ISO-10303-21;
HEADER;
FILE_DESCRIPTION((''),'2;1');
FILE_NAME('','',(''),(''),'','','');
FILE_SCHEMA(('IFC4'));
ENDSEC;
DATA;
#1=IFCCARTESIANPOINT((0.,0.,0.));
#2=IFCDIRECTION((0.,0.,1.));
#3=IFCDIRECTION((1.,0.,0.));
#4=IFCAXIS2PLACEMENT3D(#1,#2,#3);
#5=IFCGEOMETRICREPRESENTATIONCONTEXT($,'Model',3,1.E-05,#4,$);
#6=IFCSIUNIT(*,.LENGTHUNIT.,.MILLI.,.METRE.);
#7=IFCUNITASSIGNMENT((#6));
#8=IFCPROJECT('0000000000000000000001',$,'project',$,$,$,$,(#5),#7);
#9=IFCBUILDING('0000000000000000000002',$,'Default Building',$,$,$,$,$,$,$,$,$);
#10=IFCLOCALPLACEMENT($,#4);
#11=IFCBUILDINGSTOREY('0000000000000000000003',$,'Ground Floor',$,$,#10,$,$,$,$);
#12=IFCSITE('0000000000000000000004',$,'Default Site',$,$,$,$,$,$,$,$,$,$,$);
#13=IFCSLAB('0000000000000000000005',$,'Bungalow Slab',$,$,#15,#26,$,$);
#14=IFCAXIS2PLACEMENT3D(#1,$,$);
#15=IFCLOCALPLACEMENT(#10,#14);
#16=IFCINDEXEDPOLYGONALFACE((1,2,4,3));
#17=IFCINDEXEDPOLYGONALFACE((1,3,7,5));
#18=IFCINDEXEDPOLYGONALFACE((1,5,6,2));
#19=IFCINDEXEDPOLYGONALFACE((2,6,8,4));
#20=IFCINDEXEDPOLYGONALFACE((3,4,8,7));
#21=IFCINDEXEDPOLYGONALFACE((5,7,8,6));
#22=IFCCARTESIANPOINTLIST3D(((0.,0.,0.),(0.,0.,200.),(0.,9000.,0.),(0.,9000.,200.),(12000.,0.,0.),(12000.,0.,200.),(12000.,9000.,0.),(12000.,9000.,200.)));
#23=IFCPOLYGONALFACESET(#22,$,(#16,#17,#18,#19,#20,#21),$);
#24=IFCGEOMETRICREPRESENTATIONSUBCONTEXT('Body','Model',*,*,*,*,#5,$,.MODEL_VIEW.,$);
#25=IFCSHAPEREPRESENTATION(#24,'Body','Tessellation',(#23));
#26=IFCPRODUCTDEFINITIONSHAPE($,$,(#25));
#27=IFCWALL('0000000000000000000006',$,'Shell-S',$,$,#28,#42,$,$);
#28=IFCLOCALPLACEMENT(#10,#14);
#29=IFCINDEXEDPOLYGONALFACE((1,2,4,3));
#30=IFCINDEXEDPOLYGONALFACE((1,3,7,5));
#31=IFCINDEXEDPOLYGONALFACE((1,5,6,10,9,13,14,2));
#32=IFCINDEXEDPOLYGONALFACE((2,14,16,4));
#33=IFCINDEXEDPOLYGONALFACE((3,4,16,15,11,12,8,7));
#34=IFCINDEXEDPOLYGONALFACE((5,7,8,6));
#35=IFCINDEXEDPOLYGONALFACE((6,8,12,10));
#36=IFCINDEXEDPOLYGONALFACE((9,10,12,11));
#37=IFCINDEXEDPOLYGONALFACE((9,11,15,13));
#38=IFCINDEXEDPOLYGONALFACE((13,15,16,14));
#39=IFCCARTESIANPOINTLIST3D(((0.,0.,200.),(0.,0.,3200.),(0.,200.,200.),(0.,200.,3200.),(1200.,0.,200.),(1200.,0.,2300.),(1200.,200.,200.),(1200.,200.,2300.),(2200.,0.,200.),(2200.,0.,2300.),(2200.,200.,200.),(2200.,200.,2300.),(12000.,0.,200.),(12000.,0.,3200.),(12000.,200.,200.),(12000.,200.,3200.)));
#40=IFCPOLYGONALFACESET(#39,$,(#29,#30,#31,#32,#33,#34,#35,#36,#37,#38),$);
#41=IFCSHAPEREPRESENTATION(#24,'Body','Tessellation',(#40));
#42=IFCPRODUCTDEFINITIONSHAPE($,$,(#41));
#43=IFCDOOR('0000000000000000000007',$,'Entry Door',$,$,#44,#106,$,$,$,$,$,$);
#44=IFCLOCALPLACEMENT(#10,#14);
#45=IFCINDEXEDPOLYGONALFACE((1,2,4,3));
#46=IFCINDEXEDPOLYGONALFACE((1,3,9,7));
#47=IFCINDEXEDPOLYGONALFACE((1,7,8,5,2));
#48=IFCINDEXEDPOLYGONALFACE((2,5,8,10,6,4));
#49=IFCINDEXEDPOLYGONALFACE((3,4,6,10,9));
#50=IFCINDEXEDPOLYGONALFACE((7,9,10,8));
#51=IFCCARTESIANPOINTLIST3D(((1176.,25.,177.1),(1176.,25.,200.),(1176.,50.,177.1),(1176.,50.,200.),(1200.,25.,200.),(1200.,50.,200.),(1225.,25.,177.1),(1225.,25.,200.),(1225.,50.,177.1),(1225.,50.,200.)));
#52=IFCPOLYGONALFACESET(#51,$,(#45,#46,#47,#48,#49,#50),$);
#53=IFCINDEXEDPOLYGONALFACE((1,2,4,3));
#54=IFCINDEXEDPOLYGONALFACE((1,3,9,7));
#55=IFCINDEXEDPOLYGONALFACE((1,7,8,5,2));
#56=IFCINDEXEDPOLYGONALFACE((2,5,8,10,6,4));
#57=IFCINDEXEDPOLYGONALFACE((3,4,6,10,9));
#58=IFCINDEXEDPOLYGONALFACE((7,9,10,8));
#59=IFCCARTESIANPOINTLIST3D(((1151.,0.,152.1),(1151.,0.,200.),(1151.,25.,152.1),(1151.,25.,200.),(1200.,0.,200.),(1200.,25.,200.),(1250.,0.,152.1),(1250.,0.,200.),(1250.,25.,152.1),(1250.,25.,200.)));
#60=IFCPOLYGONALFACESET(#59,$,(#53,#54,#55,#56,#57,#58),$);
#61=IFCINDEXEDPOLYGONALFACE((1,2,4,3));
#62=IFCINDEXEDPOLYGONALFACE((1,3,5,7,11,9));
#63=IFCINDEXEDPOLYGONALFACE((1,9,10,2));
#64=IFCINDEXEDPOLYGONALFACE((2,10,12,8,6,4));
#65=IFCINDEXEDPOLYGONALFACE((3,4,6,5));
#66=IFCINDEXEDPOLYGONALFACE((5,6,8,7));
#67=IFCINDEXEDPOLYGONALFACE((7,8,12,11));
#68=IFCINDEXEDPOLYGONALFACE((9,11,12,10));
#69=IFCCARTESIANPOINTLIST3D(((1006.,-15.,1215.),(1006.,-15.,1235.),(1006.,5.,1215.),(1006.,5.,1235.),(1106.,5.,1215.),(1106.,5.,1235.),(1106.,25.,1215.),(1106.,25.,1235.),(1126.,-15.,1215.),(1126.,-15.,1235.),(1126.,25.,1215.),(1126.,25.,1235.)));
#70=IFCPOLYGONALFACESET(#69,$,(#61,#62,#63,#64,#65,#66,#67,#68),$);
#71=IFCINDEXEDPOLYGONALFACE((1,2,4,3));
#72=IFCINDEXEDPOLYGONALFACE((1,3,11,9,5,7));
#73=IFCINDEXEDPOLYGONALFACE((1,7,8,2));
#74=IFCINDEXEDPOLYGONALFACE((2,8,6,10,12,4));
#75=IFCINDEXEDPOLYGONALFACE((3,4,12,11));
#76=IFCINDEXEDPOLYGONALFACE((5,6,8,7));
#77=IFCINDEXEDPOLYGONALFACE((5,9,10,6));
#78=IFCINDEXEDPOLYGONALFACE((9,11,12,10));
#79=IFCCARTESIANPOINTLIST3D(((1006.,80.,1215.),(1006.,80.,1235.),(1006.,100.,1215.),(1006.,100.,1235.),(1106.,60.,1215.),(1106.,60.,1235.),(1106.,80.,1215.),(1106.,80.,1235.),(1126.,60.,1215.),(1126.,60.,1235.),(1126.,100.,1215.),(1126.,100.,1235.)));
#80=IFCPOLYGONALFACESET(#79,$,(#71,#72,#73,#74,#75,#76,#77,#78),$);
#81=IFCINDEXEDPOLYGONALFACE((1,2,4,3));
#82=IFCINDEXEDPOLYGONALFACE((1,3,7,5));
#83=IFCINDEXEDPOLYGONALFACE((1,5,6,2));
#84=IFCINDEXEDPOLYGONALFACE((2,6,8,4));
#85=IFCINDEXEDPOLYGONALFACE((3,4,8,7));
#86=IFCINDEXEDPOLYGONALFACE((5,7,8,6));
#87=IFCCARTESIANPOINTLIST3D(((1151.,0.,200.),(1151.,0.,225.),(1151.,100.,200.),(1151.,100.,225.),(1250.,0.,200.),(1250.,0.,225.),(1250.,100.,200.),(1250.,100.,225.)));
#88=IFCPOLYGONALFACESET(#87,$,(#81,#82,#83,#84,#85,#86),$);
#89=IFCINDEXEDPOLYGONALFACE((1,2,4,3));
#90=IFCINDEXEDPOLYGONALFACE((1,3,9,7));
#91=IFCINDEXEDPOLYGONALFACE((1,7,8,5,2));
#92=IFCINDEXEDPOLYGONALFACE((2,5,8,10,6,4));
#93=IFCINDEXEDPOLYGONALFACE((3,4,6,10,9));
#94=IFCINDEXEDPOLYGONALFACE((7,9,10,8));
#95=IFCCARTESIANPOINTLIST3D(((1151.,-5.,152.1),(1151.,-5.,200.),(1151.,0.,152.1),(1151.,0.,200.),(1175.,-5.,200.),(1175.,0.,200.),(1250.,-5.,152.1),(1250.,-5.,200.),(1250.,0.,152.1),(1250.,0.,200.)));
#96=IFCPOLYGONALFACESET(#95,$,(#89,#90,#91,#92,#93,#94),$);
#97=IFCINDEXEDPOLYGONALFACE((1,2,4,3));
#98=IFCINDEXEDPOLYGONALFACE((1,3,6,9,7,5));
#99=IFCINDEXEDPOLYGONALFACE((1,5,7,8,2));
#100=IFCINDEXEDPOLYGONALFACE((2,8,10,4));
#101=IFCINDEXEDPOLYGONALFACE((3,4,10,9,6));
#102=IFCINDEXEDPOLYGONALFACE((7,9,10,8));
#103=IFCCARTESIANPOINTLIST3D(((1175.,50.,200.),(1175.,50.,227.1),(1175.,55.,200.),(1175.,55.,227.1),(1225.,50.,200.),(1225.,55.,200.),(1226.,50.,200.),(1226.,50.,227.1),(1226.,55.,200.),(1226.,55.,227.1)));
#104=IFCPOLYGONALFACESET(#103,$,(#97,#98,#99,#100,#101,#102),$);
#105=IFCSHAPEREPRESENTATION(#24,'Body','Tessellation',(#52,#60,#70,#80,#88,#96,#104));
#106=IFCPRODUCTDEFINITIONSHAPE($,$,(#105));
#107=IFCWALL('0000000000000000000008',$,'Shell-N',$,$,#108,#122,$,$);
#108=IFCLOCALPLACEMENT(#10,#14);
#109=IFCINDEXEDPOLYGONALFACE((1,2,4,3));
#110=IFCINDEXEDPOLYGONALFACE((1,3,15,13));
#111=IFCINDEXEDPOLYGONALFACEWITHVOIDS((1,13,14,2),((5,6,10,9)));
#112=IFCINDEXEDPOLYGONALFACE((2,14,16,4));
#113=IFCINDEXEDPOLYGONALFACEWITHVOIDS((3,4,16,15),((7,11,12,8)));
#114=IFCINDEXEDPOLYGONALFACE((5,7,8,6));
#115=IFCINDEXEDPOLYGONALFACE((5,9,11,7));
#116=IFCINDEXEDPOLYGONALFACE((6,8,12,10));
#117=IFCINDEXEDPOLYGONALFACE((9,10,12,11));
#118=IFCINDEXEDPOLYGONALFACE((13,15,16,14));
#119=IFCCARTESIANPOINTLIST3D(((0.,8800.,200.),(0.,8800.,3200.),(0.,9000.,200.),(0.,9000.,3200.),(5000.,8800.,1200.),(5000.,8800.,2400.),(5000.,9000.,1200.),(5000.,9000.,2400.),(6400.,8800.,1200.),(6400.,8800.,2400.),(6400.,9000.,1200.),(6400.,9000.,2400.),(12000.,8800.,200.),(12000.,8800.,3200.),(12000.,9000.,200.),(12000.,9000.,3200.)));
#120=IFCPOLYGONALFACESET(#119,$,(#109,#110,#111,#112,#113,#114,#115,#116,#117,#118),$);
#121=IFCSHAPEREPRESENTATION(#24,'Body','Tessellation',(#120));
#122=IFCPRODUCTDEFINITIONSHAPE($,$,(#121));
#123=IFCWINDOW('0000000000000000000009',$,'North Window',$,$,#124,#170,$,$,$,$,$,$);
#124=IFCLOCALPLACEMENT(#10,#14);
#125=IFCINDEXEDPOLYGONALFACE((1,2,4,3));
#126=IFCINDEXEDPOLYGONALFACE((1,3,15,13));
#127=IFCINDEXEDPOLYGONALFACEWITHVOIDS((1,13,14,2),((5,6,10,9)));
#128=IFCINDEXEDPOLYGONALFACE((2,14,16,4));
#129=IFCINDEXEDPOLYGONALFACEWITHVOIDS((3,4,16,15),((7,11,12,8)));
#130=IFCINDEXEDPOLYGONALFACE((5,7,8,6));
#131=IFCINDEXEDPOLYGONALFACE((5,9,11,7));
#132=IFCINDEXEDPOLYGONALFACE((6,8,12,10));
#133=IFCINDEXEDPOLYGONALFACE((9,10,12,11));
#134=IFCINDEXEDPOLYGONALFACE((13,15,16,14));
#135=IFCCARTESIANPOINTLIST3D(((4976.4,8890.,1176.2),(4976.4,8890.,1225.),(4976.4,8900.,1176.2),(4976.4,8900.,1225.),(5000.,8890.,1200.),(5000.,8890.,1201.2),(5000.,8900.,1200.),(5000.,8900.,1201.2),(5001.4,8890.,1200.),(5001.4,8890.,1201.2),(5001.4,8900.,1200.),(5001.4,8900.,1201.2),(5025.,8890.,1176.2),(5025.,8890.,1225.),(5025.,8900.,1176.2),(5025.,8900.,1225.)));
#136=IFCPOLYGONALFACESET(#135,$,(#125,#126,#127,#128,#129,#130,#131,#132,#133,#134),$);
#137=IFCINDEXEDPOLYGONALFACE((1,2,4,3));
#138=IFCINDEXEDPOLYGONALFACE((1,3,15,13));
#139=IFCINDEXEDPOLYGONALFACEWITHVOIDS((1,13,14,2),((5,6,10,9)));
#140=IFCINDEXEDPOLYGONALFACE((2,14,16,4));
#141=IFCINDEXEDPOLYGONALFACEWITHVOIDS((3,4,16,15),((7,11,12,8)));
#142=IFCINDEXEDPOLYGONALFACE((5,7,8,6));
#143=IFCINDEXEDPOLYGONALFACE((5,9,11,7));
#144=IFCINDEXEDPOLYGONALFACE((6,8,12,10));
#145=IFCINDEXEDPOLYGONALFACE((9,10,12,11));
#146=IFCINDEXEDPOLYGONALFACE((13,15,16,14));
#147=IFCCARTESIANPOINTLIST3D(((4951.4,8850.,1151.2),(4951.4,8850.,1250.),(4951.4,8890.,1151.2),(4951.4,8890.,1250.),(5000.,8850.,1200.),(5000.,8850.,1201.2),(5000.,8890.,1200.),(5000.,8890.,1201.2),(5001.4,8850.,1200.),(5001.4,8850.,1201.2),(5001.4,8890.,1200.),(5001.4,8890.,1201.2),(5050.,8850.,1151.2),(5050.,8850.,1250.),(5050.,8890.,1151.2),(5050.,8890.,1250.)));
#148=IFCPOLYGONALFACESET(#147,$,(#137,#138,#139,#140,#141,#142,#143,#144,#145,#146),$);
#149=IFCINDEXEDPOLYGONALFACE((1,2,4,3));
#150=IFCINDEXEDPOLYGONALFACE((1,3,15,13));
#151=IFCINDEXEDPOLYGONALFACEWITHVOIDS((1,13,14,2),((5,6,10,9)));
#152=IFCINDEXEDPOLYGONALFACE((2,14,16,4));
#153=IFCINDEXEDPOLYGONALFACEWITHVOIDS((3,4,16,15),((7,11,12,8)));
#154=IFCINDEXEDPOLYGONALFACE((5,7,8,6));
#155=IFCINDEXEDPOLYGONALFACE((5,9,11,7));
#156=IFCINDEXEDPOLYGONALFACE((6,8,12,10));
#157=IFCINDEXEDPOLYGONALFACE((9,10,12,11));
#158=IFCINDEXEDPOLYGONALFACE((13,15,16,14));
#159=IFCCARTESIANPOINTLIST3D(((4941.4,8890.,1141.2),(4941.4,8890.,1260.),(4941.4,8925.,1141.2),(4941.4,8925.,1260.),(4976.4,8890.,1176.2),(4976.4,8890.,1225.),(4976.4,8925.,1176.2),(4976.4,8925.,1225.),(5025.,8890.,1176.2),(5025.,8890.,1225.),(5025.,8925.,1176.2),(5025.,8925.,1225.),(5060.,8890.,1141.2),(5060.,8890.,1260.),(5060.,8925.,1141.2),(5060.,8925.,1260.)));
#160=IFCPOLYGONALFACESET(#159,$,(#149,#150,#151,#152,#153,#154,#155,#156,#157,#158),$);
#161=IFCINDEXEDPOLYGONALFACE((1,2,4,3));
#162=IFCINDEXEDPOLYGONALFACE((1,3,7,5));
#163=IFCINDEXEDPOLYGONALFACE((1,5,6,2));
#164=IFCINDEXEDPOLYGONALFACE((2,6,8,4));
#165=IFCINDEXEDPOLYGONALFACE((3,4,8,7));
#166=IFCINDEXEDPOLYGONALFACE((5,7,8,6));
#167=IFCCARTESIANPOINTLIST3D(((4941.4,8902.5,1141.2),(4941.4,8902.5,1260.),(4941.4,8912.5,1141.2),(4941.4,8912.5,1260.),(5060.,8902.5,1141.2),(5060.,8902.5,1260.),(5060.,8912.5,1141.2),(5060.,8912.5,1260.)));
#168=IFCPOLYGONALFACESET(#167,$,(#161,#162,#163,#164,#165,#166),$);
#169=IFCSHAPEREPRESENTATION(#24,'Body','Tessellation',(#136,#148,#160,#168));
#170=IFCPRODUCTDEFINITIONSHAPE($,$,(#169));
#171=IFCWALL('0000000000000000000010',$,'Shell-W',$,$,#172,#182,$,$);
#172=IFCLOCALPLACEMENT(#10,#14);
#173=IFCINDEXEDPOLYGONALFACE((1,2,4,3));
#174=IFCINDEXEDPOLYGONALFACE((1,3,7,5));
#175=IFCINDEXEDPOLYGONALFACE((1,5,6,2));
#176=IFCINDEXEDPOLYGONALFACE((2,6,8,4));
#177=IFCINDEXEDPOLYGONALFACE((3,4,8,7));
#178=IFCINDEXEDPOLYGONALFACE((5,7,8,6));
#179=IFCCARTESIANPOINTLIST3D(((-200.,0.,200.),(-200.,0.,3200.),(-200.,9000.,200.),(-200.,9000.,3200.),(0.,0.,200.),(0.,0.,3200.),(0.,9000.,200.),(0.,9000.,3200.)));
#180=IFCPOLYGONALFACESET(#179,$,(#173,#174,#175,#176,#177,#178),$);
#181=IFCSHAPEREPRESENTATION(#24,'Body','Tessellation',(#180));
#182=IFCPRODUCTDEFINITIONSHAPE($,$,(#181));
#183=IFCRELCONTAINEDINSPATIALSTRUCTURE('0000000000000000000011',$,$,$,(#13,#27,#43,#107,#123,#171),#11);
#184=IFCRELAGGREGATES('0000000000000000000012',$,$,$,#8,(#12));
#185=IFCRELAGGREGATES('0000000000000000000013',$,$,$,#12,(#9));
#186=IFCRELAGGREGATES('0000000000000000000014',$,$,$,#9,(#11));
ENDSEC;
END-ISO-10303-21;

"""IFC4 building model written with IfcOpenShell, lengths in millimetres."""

from ifc_helpers import new_model, si_unit, frame, origin_with_axes, place, context, subcontext, project, spatial, line, indexed_curve, outline, extrude, element, fill, save


model = new_model("IFC4")

# Units and contexts
model_context = context("Model", 3, precision=1e-05, world=origin_with_axes())
body_context = subcontext(model_context, "Body", "Model", "MODEL_VIEW")
ifc_project = project(units=[si_unit("LENGTHUNIT", "METRE", prefix="MILLI")], contexts=[model_context])

# Site, building, storey
site = spatial("IfcSite", under=ifc_project, Name="Default Site")
building = spatial("IfcBuilding", under=site, Name="Default Building")
storey_placement = place(None, origin_with_axes())
storey = spatial("IfcBuildingStorey", under=building, at=storey_placement, Name="Ground Floor")

# Slab
slab_placement = place(storey_placement, origin_with_axes())
element("IfcSlab", 1, at=slab_placement, inside=storey, Name="Bungalow Slab", context=body_context, shape_type="SweptSolid", body=[
    extrude(outline(indexed_curve([(0.0, 0.0), (12000.0, 0.0), (12000.0, 9000.0), (0.0, 9000.0), (0.0, 0.0)])), None, (0.0, 0.0, 1.0), 200.0),
])

# Wall, opening, door
wall_1_placement = place(storey_placement, frame((0.0, 0.0, 200.0), z_axis=(0.0, 0.0, 1.0), x_axis=(1.0, 0.0, 0.0)))
wall_1 = element("IfcWall", 2, at=wall_1_placement, inside=storey, Name="Shell-S", context=body_context, shape_type="SweptSolid", body=[
    extrude(outline(indexed_curve([(0.0, 0.0), (12000.0, 0.0), (12000.0, 200.0), (0.0, 200.0), (0.0, 0.0)])), None, (0.0, 0.0, 1.0), 3000.0),
])
opening_1_placement = place(wall_1_placement, origin_with_axes())
opening_1 = element("IfcOpeningElement", 3, at=opening_1_placement, cuts=wall_1, context=body_context, shape_type="SweptSolid", body=[
    extrude(outline(indexed_curve([(1200.0, 0.0), (2200.0, 0.0), (2200.0, 200.0), (1200.0, 200.0), (1200.0, 0.0)])), None, (0.0, 0.0, 1.0), 2100.0),
])
door_1_placement = place(storey_placement, frame((1200.0, 0.0, 200.0), z_axis=(0.0, 0.0, 1.0), x_axis=(1.0, 0.0, 0.0)))
door_1 = element("IfcDoor", 4, at=door_1_placement, inside=storey, Name="Entry Door", context=body_context, shape_type="SweptSolid", body=[
    extrude(outline(indexed_curve([(0.0, 0.0), (0.0, 2.1), (1.0, 2.1), (1.0, 0.0), (-24.0, 0.0), (-24.0, -22.9), (25.0, -22.9), (25.0, 0.0)], segments=[line(1, 2, 3, 4, 5, 6, 7, 8, 1)])), frame((0.0, 25.0, 0.0), z_axis=(0.0, -1.0, 0.0), x_axis=(1.0, 0.0, 0.0)), (0.0, 0.0, -1.0), 25.0),
    extrude(outline(indexed_curve([(0.0, 0.0), (0.0, 2.1), (1.0, 2.1), (1.0, 0.0), (-49.0, 0.0), (-49.0, -47.9), (50.0, -47.9), (50.0, 0.0)], segments=[line(1, 2, 3, 4, 5, 6, 7, 8, 1)])), frame((0.0, 0.0, 0.0), z_axis=(0.0, -1.0, 0.0), x_axis=(1.0, 0.0, 0.0)), (0.0, 0.0, -1.0), 25.0),
    extrude(outline(indexed_curve([(0.0, 0.0), (-49.0, 0.0), (-49.0, 35.0), (0.0, 35.0)], segments=[line(1, 2, 3, 4, 1)])), frame((25.0, 25.0, 25.0), z_axis=(0.0, 0.0, 1.0), x_axis=(1.0, 0.0, 0.0)), (0.0, 0.0, 1.0), -47.9),
    extrude(outline(indexed_curve([(0.0, 0.0), (0.0, -40.0), (-120.0, -40.0), (-120.0, -20.0), (-20.0, -20.0), (-20.0, 0.0)], segments=[line(1, 2, 3, 4, 5, 6, 1)])), frame((-74.0, 25.0, 1015.0), z_axis=(0.0, 0.0, 1.0), x_axis=(1.0, 0.0, 0.0)), (0.0, 0.0, 1.0), 20.0),
    extrude(outline(indexed_curve([(0.0, 0.0), (0.0, 40.0), (-120.0, 40.0), (-120.0, 20.0), (-20.0, 20.0), (-20.0, 0.0)], segments=[line(1, 2, 3, 4, 5, 6, 1)])), frame((-74.0, 60.0, 1015.0), z_axis=(0.0, 0.0, 1.0), x_axis=(1.0, 0.0, 0.0)), (0.0, 0.0, 1.0), 20.0),
    extrude(outline(indexed_curve([(0.0, 0.0), (-99.0, 0.0), (-99.0, 100.0), (0.0, 100.0)], segments=[line(1, 2, 3, 4, 1)])), frame((50.0, 0.0, 0.0), z_axis=(0.0, 0.0, 1.0), x_axis=(1.0, 0.0, 0.0)), (0.0, 0.0, 1.0), 25.0),
    extrude(outline(indexed_curve([(0.0, 0.0), (0.0, 27.1), (51.0, 27.1), (51.0, 0.0), (-24.0, 0.0), (-24.0, -47.9), (75.0, -47.9), (75.0, 0.0)], segments=[line(1, 2, 3, 4, 5, 6, 7, 8, 1)])), frame((-25.0, -5.0, 0.0), z_axis=(0.0, -1.0, 0.0), x_axis=(1.0, 0.0, 0.0)), (0.0, 0.0, -1.0), 5.0),
    extrude(outline(indexed_curve([(0.0, 0.0), (0.0, 27.1), (51.0, 27.1), (51.0, 0.0), (1.0, 0.0), (1.0, -22.9), (50.0, -22.9), (50.0, 0.0)], segments=[line(1, 2, 3, 4, 5, 6, 7, 8, 1)])), frame((-25.0, 50.0, 0.0), z_axis=(0.0, -1.0, 0.0), x_axis=(1.0, 0.0, 0.0)), (0.0, 0.0, -1.0), 5.0),
])
fill(opening_1, door_1)

# Wall, opening, window
wall_2_placement = place(storey_placement, frame((0.0, 0.0, 200.0), z_axis=(0.0, 0.0, 1.0), x_axis=(1.0, 0.0, 0.0)))
wall_2 = element("IfcWall", 5, at=wall_2_placement, inside=storey, Name="Shell-N", context=body_context, shape_type="SweptSolid", body=[
    extrude(outline(indexed_curve([(0.0, 8800.0), (12000.0, 8800.0), (12000.0, 9000.0), (0.0, 9000.0), (0.0, 8800.0)])), None, (0.0, 0.0, 1.0), 3000.0),
])
opening_2_placement = place(wall_2_placement, frame((0.0, 0.0, 1000.0), z_axis=(0.0, 0.0, 1.0), x_axis=(1.0, 0.0, 0.0)))
opening_2 = element("IfcOpeningElement", 6, at=opening_2_placement, cuts=wall_2, context=body_context, shape_type="SweptSolid", body=[
    extrude(outline(indexed_curve([(5000.0, 8800.0), (6400.0, 8800.0), (6400.0, 9000.0), (5000.0, 9000.0), (5000.0, 8800.0)])), None, (0.0, 0.0, 1.0), 1200.0),
])
window_1_placement = place(storey_placement, frame((5000.0, 8800.0, 1200.0), z_axis=(0.0, 0.0, 1.0), x_axis=(1.0, 0.0, 0.0)))
window_1 = element("IfcWindow", 7, at=window_1_placement, inside=storey, Name="North Window", context=body_context, shape_type="SweptSolid", body=[
    extrude(outline(indexed_curve([(0.0, 0.0), (1.4, 0.0), (1.4, 1.2), (0.0, 1.2)], segments=[line(1, 2, 3, 4, 1)]), holes=[indexed_curve([(25.0, 25.0), (-23.6, 25.0), (-23.6, -23.8), (25.0, -23.8)], segments=[line(1, 2, 3, 4, 1)])]), frame((0.0, 90.0, 0.0), z_axis=(0.0, -1.0, 0.0), x_axis=(1.0, 0.0, 0.0)), (0.0, 0.0, -1.0), 10.0),
    extrude(outline(indexed_curve([(0.0, 0.0), (1.4, 0.0), (1.4, 1.2), (0.0, 1.2)], segments=[line(1, 2, 3, 4, 1)]), holes=[indexed_curve([(50.0, 50.0), (-48.6, 50.0), (-48.6, -48.8), (50.0, -48.8)], segments=[line(1, 2, 3, 4, 1)])]), frame((0.0, 50.0, 0.0), z_axis=(0.0, -1.0, 0.0), x_axis=(1.0, 0.0, 0.0)), (0.0, 0.0, -1.0), 40.0),
    extrude(outline(indexed_curve([(0.0, 0.0), (-48.6, 0.0), (-48.6, -48.8), (0.0, -48.8)], segments=[line(1, 2, 3, 4, 1)]), holes=[indexed_curve([(35.0, 35.0), (-83.6, 35.0), (-83.6, -83.8), (35.0, -83.8)], segments=[line(1, 2, 3, 4, 1)])]), frame((25.0, 90.0, 25.0), z_axis=(0.0, -1.0, 0.0), x_axis=(1.0, 0.0, 0.0)), (0.0, 0.0, -1.0), 35.0),
    extrude(outline(indexed_curve([(35.0, 35.0), (-83.6, 35.0), (-83.6, -83.8), (35.0, -83.8)], segments=[line(1, 2, 3, 4, 1)])), frame((25.0, 102.5, 25.0), z_axis=(0.0, -1.0, 0.0), x_axis=(1.0, 0.0, 0.0)), (0.0, 0.0, -1.0), 10.0),
])
fill(opening_2, window_1)

# Wall
wall_3_placement = place(storey_placement, frame((0.0, 0.0, 200.0), z_axis=(0.0, 0.0, 1.0), x_axis=(1.0, 0.0, 0.0)))
element("IfcWall", 8, at=wall_3_placement, inside=storey, Name="Shell-W", context=body_context, shape_type="SweptSolid", body=[
    extrude(outline(indexed_curve([(0.0, 0.0), (0.0, 9000.0), (-200.0, 9000.0), (-200.0, 0.0), (0.0, 0.0)])), None, (0.0, 0.0, 1.0), 3000.0),
])

save(model, "model.ifc")
